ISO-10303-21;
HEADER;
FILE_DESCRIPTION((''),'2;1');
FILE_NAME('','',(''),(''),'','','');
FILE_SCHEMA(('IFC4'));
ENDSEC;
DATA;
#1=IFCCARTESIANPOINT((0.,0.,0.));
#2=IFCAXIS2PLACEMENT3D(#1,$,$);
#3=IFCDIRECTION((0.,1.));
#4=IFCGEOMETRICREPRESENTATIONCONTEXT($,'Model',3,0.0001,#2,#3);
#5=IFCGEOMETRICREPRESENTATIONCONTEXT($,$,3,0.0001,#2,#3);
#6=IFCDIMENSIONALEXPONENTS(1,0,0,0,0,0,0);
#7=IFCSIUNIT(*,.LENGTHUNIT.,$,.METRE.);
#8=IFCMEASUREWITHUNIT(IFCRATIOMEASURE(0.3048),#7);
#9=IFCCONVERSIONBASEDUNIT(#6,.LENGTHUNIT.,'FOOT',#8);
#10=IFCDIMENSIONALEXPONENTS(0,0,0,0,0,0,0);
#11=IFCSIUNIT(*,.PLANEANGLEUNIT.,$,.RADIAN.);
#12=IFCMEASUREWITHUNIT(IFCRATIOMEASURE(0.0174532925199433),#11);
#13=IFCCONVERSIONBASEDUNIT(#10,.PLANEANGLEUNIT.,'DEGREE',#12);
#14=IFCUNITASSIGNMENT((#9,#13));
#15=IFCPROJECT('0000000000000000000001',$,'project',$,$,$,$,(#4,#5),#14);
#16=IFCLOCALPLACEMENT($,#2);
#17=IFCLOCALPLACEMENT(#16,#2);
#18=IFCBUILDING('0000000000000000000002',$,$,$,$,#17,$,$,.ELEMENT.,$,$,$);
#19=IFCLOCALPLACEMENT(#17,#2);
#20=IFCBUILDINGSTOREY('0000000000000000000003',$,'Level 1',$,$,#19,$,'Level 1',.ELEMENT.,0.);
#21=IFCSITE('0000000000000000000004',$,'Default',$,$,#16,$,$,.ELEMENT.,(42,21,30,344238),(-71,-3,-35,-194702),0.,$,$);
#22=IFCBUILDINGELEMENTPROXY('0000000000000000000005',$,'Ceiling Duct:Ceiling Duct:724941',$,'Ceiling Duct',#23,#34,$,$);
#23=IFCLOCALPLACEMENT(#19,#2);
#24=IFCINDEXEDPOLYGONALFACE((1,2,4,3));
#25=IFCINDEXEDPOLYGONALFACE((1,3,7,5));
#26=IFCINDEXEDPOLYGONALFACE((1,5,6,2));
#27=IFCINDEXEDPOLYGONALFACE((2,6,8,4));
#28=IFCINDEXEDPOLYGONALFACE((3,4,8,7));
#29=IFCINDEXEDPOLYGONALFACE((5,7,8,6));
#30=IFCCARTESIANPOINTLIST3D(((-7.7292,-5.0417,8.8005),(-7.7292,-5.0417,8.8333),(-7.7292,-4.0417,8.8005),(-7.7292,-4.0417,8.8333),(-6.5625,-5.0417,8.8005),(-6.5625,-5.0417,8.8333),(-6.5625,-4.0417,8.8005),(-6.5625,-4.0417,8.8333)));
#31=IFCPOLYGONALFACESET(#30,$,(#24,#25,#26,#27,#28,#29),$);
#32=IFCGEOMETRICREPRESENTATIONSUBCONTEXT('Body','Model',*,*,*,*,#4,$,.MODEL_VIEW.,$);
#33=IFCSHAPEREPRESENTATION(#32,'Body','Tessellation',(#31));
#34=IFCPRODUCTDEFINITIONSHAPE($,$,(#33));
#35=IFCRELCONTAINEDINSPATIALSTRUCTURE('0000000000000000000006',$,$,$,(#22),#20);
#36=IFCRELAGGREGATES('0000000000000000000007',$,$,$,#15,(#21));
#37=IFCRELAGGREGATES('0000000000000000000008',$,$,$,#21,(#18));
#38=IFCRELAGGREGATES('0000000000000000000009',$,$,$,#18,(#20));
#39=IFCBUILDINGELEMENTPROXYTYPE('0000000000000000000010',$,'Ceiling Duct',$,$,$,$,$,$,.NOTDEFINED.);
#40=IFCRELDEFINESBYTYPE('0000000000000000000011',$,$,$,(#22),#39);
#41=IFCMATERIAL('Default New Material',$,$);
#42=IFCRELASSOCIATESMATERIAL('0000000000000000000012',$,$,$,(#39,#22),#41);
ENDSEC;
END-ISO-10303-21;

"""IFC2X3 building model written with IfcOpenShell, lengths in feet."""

from ifc_helpers import new_model, entity, si_unit, converted_unit, direction, frame, origin, origin_2d_with_axis, place, context, subcontext, project, spatial, rectangle, extrude, source, transform, mapped, material, type_object, type_shapes, element, save


model = new_model("IFC2X3")

# Units and contexts
model_context = context("Model", 3, precision=0.0001, world=origin(), true_north=direction((0.0, 1.0)))
context_of_model = context(None, 3, precision=0.0001, world=origin(), true_north=direction((0.0, 1.0)))
body_context = subcontext(model_context, "Body", "Model", "MODEL_VIEW")
ifc_project = project(units=[converted_unit("LENGTHUNIT", "FOOT", entity("IfcRatioMeasure", 0.3048), si_unit("LENGTHUNIT", "METRE"), dimensions=[1, 0, 0, 0, 0, 0, 0]), converted_unit("PLANEANGLEUNIT", "DEGREE", entity("IfcRatioMeasure", 0.0174532925199433), si_unit("PLANEANGLEUNIT", "RADIAN"), dimensions=[0, 0, 0, 0, 0, 0, 0])], contexts=[model_context, context_of_model])

# Site, building, storey
site_placement = place(None, origin())
site = spatial("IfcSite", under=ifc_project, at=site_placement, Name="Default", CompositionType="ELEMENT", RefLatitude=(42, 21, 30, 344238), RefLongitude=(-71, -3, -35, -194702), RefElevation=0.0)
building_placement = place(site_placement, origin())
building = spatial("IfcBuilding", under=site, at=building_placement, CompositionType="ELEMENT")
storey_placement = place(building_placement, origin())
storey = spatial("IfcBuildingStorey", under=building, at=storey_placement, Name="Level 1", LongName="Level 1", CompositionType="ELEMENT", Elevation=0.0)

# Shared definitions
ifc_material = material(Name="Default New Material")

# Building element proxy
building_element_proxy_type_1 = type_object("IfcBuildingElementProxyType", Name="Ceiling Duct", PredefinedType="NOTDEFINED", material=ifc_material)
shared_shape_1 = source(origin(), body_context, "Body", "SweptSolid", [
    extrude(rectangle(XDim=1.0, YDim=1.1667, at=origin_2d_with_axis()), frame((0.5833, -0.5, -0.0328), z_axis=(0.0, 0.0, 1.0), x_axis=(0.0, 1.0, 0.0)), (0.0, 0.0, 1.0), 0.0328),
])
type_shapes(building_element_proxy_type_1, [shared_shape_1])
proxy_1_placement = place(storey_placement, frame((-7.7292, -4.0417, 8.8333)))
element("IfcBuildingElementProxy", 1, at=proxy_1_placement, inside=storey, type_object=building_element_proxy_type_1, material=ifc_material, Name="Ceiling Duct:Ceiling Duct:724941", ObjectType="Ceiling Duct", context=body_context, shape_type="MappedRepresentation", body=[
    mapped(shared_shape_1, transform((0.0, 0.0, 0.0), scale=1.0)),
])

save(model, "model.ifc")
